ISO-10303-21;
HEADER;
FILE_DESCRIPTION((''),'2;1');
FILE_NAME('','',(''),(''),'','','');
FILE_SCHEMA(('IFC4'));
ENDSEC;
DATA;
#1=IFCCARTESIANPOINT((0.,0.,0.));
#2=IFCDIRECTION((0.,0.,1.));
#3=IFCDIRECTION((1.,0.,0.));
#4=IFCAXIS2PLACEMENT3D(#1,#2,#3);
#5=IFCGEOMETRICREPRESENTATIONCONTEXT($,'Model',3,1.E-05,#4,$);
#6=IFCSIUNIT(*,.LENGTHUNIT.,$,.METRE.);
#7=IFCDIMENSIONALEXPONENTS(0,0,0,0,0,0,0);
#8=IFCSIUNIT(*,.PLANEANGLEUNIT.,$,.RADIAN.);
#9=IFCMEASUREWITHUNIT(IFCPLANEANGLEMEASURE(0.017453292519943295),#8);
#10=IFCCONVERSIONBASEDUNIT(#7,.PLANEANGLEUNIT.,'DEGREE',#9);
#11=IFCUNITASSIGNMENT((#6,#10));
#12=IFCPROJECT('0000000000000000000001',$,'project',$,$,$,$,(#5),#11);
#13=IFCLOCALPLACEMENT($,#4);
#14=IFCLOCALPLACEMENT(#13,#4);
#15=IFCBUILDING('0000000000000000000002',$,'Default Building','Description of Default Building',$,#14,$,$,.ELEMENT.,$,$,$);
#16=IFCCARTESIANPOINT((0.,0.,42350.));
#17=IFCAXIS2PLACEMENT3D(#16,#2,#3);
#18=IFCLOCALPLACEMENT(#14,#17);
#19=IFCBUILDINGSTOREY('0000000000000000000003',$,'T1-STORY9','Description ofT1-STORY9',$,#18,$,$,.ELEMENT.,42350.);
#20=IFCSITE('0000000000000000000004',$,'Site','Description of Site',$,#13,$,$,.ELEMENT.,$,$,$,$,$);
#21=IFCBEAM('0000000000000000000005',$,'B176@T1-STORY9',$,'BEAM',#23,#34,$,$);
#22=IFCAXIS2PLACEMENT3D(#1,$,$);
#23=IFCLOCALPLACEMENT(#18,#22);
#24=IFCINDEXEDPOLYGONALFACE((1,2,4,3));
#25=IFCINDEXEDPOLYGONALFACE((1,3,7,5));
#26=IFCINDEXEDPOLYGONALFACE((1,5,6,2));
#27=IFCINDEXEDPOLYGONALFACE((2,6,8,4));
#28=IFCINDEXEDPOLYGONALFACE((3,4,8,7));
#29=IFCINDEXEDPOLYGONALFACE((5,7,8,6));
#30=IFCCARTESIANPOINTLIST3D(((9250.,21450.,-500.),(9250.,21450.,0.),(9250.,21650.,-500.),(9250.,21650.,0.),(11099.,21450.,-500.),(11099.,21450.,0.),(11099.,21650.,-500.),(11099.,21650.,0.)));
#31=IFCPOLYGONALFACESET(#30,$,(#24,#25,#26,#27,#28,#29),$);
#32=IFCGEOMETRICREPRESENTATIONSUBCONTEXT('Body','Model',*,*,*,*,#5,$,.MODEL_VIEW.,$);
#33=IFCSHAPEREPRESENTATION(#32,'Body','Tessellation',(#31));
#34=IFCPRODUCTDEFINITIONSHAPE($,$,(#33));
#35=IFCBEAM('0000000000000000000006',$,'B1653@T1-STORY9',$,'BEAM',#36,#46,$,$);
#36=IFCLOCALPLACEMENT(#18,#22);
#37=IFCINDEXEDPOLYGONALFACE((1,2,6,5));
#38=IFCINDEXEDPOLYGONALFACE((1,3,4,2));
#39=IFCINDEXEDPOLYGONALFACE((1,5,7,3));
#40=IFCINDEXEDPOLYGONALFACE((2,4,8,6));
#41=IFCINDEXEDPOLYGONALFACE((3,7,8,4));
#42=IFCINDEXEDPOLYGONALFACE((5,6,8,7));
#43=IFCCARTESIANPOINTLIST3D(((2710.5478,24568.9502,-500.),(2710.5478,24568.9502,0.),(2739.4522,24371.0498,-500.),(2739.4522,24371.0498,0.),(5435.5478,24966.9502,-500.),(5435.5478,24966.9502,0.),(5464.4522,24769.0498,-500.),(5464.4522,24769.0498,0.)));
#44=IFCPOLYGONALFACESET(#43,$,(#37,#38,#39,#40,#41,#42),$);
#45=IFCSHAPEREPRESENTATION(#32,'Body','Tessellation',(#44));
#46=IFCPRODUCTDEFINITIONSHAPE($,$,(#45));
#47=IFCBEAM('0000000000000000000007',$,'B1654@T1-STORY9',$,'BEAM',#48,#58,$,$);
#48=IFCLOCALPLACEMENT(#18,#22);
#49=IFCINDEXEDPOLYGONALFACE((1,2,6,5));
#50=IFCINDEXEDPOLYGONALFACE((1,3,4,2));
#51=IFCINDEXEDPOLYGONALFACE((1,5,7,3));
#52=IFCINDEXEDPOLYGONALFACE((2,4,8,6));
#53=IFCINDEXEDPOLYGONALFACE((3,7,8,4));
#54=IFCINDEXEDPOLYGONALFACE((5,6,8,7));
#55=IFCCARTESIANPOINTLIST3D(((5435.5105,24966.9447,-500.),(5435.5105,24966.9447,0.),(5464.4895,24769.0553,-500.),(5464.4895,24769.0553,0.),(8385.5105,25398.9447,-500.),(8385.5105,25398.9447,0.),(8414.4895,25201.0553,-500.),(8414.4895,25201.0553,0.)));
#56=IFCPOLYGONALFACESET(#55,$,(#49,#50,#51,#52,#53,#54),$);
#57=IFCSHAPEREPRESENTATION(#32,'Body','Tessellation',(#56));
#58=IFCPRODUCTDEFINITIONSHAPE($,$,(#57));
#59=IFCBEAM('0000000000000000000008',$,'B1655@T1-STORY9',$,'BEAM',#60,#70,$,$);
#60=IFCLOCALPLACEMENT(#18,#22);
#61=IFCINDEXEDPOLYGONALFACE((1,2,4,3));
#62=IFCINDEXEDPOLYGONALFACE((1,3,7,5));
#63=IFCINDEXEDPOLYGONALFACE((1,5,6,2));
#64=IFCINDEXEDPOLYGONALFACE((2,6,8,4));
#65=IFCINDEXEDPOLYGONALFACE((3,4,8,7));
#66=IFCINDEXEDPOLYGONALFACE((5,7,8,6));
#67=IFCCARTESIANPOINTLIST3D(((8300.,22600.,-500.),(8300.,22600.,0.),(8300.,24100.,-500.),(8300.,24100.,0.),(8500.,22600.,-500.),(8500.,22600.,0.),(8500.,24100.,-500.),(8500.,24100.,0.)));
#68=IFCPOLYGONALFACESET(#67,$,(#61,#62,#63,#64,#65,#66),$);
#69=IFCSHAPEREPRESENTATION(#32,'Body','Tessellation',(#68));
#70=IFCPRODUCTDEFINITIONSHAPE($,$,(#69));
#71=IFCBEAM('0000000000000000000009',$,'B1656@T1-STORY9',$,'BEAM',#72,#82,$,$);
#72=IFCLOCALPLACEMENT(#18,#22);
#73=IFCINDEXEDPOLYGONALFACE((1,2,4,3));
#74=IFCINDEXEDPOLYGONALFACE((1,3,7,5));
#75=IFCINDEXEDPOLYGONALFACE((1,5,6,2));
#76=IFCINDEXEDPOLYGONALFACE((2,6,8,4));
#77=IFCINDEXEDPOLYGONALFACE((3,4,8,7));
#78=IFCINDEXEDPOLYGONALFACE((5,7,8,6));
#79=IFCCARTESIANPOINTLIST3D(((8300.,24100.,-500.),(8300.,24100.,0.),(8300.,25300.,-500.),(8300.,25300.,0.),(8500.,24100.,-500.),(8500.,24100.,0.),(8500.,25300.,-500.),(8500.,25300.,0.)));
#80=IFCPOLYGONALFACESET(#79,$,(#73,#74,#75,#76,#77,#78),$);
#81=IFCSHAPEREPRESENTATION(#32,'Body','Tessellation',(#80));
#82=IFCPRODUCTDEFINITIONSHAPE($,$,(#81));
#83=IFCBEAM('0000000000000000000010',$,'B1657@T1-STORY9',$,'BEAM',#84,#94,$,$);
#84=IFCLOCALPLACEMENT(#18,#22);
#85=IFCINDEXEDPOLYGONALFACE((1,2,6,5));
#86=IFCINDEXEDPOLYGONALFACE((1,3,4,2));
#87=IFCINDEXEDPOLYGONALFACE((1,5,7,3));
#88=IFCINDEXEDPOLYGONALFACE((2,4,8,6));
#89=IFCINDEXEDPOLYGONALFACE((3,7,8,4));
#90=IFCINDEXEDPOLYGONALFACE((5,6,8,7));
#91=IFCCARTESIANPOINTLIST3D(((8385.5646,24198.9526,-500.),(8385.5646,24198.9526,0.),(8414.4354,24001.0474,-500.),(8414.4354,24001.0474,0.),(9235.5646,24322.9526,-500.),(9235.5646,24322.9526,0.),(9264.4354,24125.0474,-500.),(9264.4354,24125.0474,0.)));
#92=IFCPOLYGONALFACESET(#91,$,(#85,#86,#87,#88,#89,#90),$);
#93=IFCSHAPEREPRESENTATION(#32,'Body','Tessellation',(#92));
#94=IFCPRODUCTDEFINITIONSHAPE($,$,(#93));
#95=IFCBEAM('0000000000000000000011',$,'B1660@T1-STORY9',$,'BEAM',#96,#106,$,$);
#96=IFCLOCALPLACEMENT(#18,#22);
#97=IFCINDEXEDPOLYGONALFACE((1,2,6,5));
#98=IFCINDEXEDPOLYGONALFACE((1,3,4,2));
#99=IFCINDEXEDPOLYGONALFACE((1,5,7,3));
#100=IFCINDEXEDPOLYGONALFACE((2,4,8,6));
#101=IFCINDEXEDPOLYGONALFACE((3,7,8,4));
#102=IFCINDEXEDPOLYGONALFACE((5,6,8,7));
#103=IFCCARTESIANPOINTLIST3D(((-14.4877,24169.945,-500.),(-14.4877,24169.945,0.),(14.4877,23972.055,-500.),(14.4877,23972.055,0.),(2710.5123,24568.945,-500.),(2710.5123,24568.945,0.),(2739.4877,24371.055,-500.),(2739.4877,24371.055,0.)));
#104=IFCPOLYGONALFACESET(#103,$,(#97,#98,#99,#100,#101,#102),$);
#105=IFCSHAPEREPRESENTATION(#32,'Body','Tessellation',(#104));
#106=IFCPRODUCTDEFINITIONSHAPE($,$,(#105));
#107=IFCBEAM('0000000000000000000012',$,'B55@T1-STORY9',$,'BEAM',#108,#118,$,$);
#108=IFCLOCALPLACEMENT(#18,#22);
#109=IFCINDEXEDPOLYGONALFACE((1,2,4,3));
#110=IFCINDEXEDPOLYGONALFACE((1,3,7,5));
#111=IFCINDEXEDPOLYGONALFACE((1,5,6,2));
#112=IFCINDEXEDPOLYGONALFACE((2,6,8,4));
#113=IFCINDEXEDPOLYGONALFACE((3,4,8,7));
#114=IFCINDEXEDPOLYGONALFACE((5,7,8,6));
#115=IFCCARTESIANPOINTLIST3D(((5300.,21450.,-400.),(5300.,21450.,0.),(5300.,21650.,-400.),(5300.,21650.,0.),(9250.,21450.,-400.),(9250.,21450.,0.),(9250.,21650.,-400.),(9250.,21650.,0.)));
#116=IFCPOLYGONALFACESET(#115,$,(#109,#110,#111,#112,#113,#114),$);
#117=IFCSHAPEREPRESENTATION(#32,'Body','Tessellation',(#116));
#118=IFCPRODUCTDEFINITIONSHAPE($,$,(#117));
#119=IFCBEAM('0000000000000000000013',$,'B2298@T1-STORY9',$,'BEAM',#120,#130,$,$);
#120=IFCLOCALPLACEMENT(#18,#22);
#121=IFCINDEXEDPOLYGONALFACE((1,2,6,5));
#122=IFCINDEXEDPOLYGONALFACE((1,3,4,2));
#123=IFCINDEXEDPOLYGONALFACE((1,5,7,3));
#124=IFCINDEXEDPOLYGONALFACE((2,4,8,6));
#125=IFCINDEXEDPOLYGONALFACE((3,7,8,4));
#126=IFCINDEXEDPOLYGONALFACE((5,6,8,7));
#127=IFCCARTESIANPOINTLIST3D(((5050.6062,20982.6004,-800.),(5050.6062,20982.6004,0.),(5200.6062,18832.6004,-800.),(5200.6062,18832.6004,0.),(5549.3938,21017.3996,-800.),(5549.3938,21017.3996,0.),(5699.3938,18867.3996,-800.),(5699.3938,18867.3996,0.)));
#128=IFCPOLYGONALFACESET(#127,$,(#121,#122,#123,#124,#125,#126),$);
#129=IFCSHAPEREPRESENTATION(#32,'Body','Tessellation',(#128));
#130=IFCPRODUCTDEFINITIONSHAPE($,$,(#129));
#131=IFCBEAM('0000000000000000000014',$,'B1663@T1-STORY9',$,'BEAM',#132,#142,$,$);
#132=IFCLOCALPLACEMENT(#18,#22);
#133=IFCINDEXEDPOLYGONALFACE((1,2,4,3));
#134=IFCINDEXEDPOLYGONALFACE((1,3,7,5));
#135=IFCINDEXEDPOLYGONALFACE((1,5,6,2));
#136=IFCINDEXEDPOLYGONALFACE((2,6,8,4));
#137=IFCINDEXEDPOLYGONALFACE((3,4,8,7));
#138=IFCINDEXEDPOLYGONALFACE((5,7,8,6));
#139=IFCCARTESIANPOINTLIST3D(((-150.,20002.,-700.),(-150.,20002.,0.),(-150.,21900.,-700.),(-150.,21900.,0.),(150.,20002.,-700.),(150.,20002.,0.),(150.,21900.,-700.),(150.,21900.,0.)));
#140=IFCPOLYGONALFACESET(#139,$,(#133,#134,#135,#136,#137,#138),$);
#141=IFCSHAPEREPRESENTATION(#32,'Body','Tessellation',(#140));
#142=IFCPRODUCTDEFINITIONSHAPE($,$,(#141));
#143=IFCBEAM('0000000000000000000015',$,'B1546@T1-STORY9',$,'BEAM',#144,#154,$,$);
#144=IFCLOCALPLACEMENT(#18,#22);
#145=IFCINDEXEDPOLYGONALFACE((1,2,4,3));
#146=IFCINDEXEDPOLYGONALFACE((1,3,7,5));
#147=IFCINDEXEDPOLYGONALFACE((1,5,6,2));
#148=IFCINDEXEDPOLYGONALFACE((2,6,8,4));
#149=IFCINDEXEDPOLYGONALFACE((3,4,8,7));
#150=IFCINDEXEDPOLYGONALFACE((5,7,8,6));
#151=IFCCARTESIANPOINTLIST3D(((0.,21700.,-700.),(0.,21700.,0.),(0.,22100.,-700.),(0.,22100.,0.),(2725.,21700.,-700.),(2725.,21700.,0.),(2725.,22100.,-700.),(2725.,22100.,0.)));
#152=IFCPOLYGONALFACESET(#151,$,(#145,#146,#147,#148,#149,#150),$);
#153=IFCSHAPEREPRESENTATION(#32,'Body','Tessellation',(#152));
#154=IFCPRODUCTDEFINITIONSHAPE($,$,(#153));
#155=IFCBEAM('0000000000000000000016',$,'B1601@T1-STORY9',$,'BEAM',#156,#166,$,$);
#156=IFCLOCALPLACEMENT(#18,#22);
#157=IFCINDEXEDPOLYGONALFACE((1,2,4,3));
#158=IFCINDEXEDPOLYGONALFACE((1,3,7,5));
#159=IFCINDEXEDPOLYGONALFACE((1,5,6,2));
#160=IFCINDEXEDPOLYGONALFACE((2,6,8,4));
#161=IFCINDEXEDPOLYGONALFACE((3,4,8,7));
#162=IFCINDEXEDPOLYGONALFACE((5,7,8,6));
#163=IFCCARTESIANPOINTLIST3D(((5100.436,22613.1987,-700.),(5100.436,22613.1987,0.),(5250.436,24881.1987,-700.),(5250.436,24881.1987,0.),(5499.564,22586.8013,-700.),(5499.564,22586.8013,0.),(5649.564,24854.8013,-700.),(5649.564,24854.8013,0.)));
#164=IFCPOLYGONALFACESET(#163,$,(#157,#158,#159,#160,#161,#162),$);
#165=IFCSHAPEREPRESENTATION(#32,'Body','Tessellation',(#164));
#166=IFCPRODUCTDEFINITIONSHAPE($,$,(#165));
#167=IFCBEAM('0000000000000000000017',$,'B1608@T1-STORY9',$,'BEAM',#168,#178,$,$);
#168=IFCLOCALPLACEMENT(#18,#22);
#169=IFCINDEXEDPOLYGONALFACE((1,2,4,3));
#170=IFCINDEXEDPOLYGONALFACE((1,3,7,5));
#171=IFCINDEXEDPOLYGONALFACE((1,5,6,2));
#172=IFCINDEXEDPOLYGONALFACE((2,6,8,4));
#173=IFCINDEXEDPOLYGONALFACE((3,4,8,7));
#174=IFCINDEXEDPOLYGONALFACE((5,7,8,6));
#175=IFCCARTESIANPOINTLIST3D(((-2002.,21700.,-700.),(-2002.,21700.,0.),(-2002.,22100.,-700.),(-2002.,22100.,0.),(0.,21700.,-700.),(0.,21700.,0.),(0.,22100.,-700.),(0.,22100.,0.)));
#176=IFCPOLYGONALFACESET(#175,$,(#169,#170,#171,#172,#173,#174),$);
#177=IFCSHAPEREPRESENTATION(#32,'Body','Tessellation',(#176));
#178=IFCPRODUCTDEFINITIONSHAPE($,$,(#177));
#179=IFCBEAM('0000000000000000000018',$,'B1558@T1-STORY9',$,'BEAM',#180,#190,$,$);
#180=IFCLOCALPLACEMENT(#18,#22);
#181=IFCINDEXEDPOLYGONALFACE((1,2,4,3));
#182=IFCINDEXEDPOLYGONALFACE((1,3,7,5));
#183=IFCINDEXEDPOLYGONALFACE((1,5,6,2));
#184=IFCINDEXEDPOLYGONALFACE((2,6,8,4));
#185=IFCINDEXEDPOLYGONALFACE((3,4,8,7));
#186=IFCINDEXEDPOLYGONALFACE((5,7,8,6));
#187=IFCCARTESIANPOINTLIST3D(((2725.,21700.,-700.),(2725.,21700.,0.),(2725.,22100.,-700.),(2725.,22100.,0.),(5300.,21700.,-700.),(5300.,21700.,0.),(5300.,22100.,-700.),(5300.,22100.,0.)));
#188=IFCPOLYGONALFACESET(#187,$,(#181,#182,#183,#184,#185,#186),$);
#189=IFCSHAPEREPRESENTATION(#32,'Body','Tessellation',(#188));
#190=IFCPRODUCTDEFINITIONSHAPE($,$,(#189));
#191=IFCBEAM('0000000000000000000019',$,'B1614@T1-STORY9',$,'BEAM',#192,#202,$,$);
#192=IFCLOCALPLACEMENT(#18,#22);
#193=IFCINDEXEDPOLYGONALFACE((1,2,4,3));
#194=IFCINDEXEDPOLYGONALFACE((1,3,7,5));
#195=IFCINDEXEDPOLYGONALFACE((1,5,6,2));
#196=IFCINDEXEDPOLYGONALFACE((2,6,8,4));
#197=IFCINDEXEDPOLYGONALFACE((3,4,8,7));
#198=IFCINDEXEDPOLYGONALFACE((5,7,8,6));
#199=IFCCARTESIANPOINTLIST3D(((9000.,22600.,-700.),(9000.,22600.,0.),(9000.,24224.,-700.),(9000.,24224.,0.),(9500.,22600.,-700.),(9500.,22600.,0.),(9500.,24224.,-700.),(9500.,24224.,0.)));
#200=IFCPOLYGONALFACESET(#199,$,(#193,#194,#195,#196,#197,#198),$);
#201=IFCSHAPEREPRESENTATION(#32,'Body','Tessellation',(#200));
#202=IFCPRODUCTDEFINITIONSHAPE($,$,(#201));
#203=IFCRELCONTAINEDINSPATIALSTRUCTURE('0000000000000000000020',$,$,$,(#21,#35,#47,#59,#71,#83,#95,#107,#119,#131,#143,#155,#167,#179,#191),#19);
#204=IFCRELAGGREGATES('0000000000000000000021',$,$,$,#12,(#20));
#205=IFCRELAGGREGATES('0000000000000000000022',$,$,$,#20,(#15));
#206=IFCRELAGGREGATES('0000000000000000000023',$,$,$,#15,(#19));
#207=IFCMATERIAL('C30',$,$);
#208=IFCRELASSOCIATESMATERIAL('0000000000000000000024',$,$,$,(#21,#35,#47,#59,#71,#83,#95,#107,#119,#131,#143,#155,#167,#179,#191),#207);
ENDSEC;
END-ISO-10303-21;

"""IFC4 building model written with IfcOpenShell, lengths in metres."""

from ifc_helpers import new_model, entity, si_unit, converted_unit, frame, origin_with_axes, place, context, subcontext, project, spatial, rectangle, extrude, material, element, save


model = new_model("IFC4")

# Units and contexts
model_context = context("Model", 3, precision=1e-05, world=origin_with_axes())
body_context = subcontext(model_context, "Body", "Model", "MODEL_VIEW")
ifc_project = project(units=[si_unit("LENGTHUNIT", "METRE"), converted_unit("PLANEANGLEUNIT", "DEGREE", entity("IfcPlaneAngleMeasure", 0.017453292519943295), si_unit("PLANEANGLEUNIT", "RADIAN"), dimensions=[0, 0, 0, 0, 0, 0, 0])], contexts=[model_context])

# Site, building, storey
site_placement = place(None, origin_with_axes())
site = spatial("IfcSite", under=ifc_project, at=site_placement, Name="Site", Description="Description of Site", CompositionType="ELEMENT")
building_placement = place(site_placement, origin_with_axes())
building = spatial("IfcBuilding", under=site, at=building_placement, Name="Default Building", Description="Description of Default Building", CompositionType="ELEMENT")
storey_placement = place(building_placement, frame((0.0, 0.0, 42350.0), z_axis=(0.0, 0.0, 1.0), x_axis=(1.0, 0.0, 0.0)))
storey = spatial("IfcBuildingStorey", under=building, at=storey_placement, Name="T1-STORY9", Description="Description ofT1-STORY9", CompositionType="ELEMENT", Elevation=42350.0)

# Beams
ifc_material_1 = material(Name="C30")
beam_1_placement = place(storey_placement, frame((9250.0, 21550.0, -250.0), z_axis=(1.0, 0.0, 0.0), x_axis=(0.0, 1.0, 0.0)))
element("IfcBeam", 1, at=beam_1_placement, inside=storey, material=ifc_material_1, Name="B176@T1-STORY9", ObjectType="BEAM", context=body_context, shape_type="SweptSolid", body=[
    extrude(rectangle(XDim=200.0, YDim=500.0), origin_with_axes(), (0.0, 0.0, 1.0), 1849.0),
])
beam_2_placement = place(storey_placement, frame((2725.0, 24470.0, -250.0), z_axis=(0.989502, 0.144522, 0.0), x_axis=(-0.144522, 0.989502, 0.0)))
element("IfcBeam", 2, at=beam_2_placement, inside=storey, material=ifc_material_1, Name="B1653@T1-STORY9", ObjectType="BEAM", context=body_context, shape_type="SweptSolid", body=[
    extrude(rectangle(XDim=200.0, YDim=500.0), origin_with_axes(), (0.0, 0.0, 1.0), 2753.9116),
])
beam_3_placement = place(storey_placement, frame((5450.0, 24868.0, -250.0), z_axis=(0.989447, 0.144895, 0.0), x_axis=(-0.144895, 0.989447, 0.0)))
element("IfcBeam", 3, at=beam_3_placement, inside=storey, material=ifc_material_1, Name="B1654@T1-STORY9", ObjectType="BEAM", context=body_context, shape_type="SweptSolid", body=[
    extrude(rectangle(XDim=200.0, YDim=500.0), origin_with_axes(), (0.0, 0.0, 1.0), 2981.4634),
])
beam_4_placement = place(storey_placement, frame((8400.0, 22600.0, -250.0), z_axis=(0.0, 1.0, 0.0), x_axis=(-1.0, 0.0, 0.0)))
element("IfcBeam", 4, at=beam_4_placement, inside=storey, material=ifc_material_1, Name="B1655@T1-STORY9", ObjectType="BEAM", context=body_context, shape_type="SweptSolid", body=[
    extrude(rectangle(XDim=200.0, YDim=500.0), origin_with_axes(), (0.0, 0.0, 1.0), 1500.0),
])
beam_5_placement = place(storey_placement, frame((8400.0, 24100.0, -250.0), z_axis=(0.0, 1.0, 0.0), x_axis=(-1.0, 0.0, 0.0)))
element("IfcBeam", 5, at=beam_5_placement, inside=storey, material=ifc_material_1, Name="B1656@T1-STORY9", ObjectType="BEAM", context=body_context, shape_type="SweptSolid", body=[
    extrude(rectangle(XDim=200.0, YDim=500.0), origin_with_axes(), (0.0, 0.0, 1.0), 1200.0),
])
beam_6_placement = place(storey_placement, frame((8400.0, 24100.0, -250.0), z_axis=(0.989526, 0.144354, 0.0), x_axis=(-0.144354, 0.989526, 0.0)))
element("IfcBeam", 6, at=beam_6_placement, inside=storey, material=ifc_material_1, Name="B1657@T1-STORY9", ObjectType="BEAM", context=body_context, shape_type="SweptSolid", body=[
    extrude(rectangle(XDim=200.0, YDim=500.0), origin_with_axes(), (0.0, 0.0, 1.0), 858.9971),
])
beam_7_placement = place(storey_placement, frame((0.0, 24071.0, -250.0), z_axis=(0.98945, 0.144877, 0.0), x_axis=(-0.144877, 0.98945, 0.0)))
element("IfcBeam", 7, at=beam_7_placement, inside=storey, material=ifc_material_1, Name="B1660@T1-STORY9", ObjectType="BEAM", context=body_context, shape_type="SweptSolid", body=[
    extrude(rectangle(XDim=200.0, YDim=500.0), origin_with_axes(), (0.0, 0.0, 1.0), 2754.0563),
])
beam_8_placement = place(storey_placement, frame((5300.0, 21550.0, -200.0), z_axis=(1.0, 0.0, 0.0), x_axis=(0.0, 1.0, 0.0)))
element("IfcBeam", 8, at=beam_8_placement, inside=storey, material=ifc_material_1, Name="B55@T1-STORY9", ObjectType="BEAM", context=body_context, shape_type="SweptSolid", body=[
    extrude(rectangle(XDim=200.0, YDim=400.0), origin_with_axes(), (0.0, 0.0, 1.0), 3950.0),
])
beam_9_placement = place(storey_placement, frame((5300.0, 21000.0, -400.0), z_axis=(0.069598, -0.997575, 0.0), x_axis=(0.997575, 0.069598, 0.0)))
element("IfcBeam", 9, at=beam_9_placement, inside=storey, material=ifc_material_1, Name="B2298@T1-STORY9", ObjectType="BEAM", context=body_context, shape_type="SweptSolid", body=[
    extrude(rectangle(XDim=500.0, YDim=800.0), origin_with_axes(), (0.0, 0.0, 1.0), 2155.2262),
])
beam_10_placement = place(storey_placement, frame((0.0, 20002.0, -350.0), z_axis=(0.0, 1.0, 0.0), x_axis=(-1.0, 0.0, 0.0)))
element("IfcBeam", 10, at=beam_10_placement, inside=storey, material=ifc_material_1, Name="B1663@T1-STORY9", ObjectType="BEAM", context=body_context, shape_type="SweptSolid", body=[
    extrude(rectangle(XDim=300.0, YDim=700.0), origin_with_axes(), (0.0, 0.0, 1.0), 1898.0),
])
beam_11_placement = place(storey_placement, frame((0.0, 21900.0, -350.0), z_axis=(1.0, 0.0, 0.0), x_axis=(0.0, 1.0, 0.0)))
element("IfcBeam", 11, at=beam_11_placement, inside=storey, material=ifc_material_1, Name="B1546@T1-STORY9", ObjectType="BEAM", context=body_context, shape_type="SweptSolid", body=[
    extrude(rectangle(XDim=400.0, YDim=700.0), origin_with_axes(), (0.0, 0.0, 1.0), 2725.0),
])
beam_12_placement = place(storey_placement, frame((5300.0, 22600.0, -350.0), z_axis=(0.065993, 0.99782, 0.0), x_axis=(-0.99782, 0.065993, 0.0)))
element("IfcBeam", 12, at=beam_12_placement, inside=storey, material=ifc_material_1, Name="B1601@T1-STORY9", ObjectType="BEAM", context=body_context, shape_type="SweptSolid", body=[
    extrude(rectangle(XDim=400.0, YDim=700.0), origin_with_axes(), (0.0, 0.0, 1.0), 2272.9549),
])
beam_13_placement = place(storey_placement, frame((-2002.0, 21900.0, -350.0), z_axis=(1.0, 0.0, 0.0), x_axis=(0.0, 1.0, 0.0)))
element("IfcBeam", 13, at=beam_13_placement, inside=storey, material=ifc_material_1, Name="B1608@T1-STORY9", ObjectType="BEAM", context=body_context, shape_type="SweptSolid", body=[
    extrude(rectangle(XDim=400.0, YDim=700.0), origin_with_axes(), (0.0, 0.0, 1.0), 2002.0),
])
beam_14_placement = place(storey_placement, frame((2725.0, 21900.0, -350.0), z_axis=(1.0, 0.0, 0.0), x_axis=(0.0, 1.0, 0.0)))
element("IfcBeam", 14, at=beam_14_placement, inside=storey, material=ifc_material_1, Name="B1558@T1-STORY9", ObjectType="BEAM", context=body_context, shape_type="SweptSolid", body=[
    extrude(rectangle(XDim=400.0, YDim=700.0), origin_with_axes(), (0.0, 0.0, 1.0), 2575.0),
])
beam_15_placement = place(storey_placement, frame((9250.0, 22600.0, -350.0), z_axis=(0.0, 1.0, 0.0), x_axis=(-1.0, 0.0, 0.0)))
element("IfcBeam", 15, at=beam_15_placement, inside=storey, material=ifc_material_1, Name="B1614@T1-STORY9", ObjectType="BEAM", context=body_context, shape_type="SweptSolid", body=[
    extrude(rectangle(XDim=500.0, YDim=700.0), origin_with_axes(), (0.0, 0.0, 1.0), 1624.0),
])

save(model, "model.ifc")
